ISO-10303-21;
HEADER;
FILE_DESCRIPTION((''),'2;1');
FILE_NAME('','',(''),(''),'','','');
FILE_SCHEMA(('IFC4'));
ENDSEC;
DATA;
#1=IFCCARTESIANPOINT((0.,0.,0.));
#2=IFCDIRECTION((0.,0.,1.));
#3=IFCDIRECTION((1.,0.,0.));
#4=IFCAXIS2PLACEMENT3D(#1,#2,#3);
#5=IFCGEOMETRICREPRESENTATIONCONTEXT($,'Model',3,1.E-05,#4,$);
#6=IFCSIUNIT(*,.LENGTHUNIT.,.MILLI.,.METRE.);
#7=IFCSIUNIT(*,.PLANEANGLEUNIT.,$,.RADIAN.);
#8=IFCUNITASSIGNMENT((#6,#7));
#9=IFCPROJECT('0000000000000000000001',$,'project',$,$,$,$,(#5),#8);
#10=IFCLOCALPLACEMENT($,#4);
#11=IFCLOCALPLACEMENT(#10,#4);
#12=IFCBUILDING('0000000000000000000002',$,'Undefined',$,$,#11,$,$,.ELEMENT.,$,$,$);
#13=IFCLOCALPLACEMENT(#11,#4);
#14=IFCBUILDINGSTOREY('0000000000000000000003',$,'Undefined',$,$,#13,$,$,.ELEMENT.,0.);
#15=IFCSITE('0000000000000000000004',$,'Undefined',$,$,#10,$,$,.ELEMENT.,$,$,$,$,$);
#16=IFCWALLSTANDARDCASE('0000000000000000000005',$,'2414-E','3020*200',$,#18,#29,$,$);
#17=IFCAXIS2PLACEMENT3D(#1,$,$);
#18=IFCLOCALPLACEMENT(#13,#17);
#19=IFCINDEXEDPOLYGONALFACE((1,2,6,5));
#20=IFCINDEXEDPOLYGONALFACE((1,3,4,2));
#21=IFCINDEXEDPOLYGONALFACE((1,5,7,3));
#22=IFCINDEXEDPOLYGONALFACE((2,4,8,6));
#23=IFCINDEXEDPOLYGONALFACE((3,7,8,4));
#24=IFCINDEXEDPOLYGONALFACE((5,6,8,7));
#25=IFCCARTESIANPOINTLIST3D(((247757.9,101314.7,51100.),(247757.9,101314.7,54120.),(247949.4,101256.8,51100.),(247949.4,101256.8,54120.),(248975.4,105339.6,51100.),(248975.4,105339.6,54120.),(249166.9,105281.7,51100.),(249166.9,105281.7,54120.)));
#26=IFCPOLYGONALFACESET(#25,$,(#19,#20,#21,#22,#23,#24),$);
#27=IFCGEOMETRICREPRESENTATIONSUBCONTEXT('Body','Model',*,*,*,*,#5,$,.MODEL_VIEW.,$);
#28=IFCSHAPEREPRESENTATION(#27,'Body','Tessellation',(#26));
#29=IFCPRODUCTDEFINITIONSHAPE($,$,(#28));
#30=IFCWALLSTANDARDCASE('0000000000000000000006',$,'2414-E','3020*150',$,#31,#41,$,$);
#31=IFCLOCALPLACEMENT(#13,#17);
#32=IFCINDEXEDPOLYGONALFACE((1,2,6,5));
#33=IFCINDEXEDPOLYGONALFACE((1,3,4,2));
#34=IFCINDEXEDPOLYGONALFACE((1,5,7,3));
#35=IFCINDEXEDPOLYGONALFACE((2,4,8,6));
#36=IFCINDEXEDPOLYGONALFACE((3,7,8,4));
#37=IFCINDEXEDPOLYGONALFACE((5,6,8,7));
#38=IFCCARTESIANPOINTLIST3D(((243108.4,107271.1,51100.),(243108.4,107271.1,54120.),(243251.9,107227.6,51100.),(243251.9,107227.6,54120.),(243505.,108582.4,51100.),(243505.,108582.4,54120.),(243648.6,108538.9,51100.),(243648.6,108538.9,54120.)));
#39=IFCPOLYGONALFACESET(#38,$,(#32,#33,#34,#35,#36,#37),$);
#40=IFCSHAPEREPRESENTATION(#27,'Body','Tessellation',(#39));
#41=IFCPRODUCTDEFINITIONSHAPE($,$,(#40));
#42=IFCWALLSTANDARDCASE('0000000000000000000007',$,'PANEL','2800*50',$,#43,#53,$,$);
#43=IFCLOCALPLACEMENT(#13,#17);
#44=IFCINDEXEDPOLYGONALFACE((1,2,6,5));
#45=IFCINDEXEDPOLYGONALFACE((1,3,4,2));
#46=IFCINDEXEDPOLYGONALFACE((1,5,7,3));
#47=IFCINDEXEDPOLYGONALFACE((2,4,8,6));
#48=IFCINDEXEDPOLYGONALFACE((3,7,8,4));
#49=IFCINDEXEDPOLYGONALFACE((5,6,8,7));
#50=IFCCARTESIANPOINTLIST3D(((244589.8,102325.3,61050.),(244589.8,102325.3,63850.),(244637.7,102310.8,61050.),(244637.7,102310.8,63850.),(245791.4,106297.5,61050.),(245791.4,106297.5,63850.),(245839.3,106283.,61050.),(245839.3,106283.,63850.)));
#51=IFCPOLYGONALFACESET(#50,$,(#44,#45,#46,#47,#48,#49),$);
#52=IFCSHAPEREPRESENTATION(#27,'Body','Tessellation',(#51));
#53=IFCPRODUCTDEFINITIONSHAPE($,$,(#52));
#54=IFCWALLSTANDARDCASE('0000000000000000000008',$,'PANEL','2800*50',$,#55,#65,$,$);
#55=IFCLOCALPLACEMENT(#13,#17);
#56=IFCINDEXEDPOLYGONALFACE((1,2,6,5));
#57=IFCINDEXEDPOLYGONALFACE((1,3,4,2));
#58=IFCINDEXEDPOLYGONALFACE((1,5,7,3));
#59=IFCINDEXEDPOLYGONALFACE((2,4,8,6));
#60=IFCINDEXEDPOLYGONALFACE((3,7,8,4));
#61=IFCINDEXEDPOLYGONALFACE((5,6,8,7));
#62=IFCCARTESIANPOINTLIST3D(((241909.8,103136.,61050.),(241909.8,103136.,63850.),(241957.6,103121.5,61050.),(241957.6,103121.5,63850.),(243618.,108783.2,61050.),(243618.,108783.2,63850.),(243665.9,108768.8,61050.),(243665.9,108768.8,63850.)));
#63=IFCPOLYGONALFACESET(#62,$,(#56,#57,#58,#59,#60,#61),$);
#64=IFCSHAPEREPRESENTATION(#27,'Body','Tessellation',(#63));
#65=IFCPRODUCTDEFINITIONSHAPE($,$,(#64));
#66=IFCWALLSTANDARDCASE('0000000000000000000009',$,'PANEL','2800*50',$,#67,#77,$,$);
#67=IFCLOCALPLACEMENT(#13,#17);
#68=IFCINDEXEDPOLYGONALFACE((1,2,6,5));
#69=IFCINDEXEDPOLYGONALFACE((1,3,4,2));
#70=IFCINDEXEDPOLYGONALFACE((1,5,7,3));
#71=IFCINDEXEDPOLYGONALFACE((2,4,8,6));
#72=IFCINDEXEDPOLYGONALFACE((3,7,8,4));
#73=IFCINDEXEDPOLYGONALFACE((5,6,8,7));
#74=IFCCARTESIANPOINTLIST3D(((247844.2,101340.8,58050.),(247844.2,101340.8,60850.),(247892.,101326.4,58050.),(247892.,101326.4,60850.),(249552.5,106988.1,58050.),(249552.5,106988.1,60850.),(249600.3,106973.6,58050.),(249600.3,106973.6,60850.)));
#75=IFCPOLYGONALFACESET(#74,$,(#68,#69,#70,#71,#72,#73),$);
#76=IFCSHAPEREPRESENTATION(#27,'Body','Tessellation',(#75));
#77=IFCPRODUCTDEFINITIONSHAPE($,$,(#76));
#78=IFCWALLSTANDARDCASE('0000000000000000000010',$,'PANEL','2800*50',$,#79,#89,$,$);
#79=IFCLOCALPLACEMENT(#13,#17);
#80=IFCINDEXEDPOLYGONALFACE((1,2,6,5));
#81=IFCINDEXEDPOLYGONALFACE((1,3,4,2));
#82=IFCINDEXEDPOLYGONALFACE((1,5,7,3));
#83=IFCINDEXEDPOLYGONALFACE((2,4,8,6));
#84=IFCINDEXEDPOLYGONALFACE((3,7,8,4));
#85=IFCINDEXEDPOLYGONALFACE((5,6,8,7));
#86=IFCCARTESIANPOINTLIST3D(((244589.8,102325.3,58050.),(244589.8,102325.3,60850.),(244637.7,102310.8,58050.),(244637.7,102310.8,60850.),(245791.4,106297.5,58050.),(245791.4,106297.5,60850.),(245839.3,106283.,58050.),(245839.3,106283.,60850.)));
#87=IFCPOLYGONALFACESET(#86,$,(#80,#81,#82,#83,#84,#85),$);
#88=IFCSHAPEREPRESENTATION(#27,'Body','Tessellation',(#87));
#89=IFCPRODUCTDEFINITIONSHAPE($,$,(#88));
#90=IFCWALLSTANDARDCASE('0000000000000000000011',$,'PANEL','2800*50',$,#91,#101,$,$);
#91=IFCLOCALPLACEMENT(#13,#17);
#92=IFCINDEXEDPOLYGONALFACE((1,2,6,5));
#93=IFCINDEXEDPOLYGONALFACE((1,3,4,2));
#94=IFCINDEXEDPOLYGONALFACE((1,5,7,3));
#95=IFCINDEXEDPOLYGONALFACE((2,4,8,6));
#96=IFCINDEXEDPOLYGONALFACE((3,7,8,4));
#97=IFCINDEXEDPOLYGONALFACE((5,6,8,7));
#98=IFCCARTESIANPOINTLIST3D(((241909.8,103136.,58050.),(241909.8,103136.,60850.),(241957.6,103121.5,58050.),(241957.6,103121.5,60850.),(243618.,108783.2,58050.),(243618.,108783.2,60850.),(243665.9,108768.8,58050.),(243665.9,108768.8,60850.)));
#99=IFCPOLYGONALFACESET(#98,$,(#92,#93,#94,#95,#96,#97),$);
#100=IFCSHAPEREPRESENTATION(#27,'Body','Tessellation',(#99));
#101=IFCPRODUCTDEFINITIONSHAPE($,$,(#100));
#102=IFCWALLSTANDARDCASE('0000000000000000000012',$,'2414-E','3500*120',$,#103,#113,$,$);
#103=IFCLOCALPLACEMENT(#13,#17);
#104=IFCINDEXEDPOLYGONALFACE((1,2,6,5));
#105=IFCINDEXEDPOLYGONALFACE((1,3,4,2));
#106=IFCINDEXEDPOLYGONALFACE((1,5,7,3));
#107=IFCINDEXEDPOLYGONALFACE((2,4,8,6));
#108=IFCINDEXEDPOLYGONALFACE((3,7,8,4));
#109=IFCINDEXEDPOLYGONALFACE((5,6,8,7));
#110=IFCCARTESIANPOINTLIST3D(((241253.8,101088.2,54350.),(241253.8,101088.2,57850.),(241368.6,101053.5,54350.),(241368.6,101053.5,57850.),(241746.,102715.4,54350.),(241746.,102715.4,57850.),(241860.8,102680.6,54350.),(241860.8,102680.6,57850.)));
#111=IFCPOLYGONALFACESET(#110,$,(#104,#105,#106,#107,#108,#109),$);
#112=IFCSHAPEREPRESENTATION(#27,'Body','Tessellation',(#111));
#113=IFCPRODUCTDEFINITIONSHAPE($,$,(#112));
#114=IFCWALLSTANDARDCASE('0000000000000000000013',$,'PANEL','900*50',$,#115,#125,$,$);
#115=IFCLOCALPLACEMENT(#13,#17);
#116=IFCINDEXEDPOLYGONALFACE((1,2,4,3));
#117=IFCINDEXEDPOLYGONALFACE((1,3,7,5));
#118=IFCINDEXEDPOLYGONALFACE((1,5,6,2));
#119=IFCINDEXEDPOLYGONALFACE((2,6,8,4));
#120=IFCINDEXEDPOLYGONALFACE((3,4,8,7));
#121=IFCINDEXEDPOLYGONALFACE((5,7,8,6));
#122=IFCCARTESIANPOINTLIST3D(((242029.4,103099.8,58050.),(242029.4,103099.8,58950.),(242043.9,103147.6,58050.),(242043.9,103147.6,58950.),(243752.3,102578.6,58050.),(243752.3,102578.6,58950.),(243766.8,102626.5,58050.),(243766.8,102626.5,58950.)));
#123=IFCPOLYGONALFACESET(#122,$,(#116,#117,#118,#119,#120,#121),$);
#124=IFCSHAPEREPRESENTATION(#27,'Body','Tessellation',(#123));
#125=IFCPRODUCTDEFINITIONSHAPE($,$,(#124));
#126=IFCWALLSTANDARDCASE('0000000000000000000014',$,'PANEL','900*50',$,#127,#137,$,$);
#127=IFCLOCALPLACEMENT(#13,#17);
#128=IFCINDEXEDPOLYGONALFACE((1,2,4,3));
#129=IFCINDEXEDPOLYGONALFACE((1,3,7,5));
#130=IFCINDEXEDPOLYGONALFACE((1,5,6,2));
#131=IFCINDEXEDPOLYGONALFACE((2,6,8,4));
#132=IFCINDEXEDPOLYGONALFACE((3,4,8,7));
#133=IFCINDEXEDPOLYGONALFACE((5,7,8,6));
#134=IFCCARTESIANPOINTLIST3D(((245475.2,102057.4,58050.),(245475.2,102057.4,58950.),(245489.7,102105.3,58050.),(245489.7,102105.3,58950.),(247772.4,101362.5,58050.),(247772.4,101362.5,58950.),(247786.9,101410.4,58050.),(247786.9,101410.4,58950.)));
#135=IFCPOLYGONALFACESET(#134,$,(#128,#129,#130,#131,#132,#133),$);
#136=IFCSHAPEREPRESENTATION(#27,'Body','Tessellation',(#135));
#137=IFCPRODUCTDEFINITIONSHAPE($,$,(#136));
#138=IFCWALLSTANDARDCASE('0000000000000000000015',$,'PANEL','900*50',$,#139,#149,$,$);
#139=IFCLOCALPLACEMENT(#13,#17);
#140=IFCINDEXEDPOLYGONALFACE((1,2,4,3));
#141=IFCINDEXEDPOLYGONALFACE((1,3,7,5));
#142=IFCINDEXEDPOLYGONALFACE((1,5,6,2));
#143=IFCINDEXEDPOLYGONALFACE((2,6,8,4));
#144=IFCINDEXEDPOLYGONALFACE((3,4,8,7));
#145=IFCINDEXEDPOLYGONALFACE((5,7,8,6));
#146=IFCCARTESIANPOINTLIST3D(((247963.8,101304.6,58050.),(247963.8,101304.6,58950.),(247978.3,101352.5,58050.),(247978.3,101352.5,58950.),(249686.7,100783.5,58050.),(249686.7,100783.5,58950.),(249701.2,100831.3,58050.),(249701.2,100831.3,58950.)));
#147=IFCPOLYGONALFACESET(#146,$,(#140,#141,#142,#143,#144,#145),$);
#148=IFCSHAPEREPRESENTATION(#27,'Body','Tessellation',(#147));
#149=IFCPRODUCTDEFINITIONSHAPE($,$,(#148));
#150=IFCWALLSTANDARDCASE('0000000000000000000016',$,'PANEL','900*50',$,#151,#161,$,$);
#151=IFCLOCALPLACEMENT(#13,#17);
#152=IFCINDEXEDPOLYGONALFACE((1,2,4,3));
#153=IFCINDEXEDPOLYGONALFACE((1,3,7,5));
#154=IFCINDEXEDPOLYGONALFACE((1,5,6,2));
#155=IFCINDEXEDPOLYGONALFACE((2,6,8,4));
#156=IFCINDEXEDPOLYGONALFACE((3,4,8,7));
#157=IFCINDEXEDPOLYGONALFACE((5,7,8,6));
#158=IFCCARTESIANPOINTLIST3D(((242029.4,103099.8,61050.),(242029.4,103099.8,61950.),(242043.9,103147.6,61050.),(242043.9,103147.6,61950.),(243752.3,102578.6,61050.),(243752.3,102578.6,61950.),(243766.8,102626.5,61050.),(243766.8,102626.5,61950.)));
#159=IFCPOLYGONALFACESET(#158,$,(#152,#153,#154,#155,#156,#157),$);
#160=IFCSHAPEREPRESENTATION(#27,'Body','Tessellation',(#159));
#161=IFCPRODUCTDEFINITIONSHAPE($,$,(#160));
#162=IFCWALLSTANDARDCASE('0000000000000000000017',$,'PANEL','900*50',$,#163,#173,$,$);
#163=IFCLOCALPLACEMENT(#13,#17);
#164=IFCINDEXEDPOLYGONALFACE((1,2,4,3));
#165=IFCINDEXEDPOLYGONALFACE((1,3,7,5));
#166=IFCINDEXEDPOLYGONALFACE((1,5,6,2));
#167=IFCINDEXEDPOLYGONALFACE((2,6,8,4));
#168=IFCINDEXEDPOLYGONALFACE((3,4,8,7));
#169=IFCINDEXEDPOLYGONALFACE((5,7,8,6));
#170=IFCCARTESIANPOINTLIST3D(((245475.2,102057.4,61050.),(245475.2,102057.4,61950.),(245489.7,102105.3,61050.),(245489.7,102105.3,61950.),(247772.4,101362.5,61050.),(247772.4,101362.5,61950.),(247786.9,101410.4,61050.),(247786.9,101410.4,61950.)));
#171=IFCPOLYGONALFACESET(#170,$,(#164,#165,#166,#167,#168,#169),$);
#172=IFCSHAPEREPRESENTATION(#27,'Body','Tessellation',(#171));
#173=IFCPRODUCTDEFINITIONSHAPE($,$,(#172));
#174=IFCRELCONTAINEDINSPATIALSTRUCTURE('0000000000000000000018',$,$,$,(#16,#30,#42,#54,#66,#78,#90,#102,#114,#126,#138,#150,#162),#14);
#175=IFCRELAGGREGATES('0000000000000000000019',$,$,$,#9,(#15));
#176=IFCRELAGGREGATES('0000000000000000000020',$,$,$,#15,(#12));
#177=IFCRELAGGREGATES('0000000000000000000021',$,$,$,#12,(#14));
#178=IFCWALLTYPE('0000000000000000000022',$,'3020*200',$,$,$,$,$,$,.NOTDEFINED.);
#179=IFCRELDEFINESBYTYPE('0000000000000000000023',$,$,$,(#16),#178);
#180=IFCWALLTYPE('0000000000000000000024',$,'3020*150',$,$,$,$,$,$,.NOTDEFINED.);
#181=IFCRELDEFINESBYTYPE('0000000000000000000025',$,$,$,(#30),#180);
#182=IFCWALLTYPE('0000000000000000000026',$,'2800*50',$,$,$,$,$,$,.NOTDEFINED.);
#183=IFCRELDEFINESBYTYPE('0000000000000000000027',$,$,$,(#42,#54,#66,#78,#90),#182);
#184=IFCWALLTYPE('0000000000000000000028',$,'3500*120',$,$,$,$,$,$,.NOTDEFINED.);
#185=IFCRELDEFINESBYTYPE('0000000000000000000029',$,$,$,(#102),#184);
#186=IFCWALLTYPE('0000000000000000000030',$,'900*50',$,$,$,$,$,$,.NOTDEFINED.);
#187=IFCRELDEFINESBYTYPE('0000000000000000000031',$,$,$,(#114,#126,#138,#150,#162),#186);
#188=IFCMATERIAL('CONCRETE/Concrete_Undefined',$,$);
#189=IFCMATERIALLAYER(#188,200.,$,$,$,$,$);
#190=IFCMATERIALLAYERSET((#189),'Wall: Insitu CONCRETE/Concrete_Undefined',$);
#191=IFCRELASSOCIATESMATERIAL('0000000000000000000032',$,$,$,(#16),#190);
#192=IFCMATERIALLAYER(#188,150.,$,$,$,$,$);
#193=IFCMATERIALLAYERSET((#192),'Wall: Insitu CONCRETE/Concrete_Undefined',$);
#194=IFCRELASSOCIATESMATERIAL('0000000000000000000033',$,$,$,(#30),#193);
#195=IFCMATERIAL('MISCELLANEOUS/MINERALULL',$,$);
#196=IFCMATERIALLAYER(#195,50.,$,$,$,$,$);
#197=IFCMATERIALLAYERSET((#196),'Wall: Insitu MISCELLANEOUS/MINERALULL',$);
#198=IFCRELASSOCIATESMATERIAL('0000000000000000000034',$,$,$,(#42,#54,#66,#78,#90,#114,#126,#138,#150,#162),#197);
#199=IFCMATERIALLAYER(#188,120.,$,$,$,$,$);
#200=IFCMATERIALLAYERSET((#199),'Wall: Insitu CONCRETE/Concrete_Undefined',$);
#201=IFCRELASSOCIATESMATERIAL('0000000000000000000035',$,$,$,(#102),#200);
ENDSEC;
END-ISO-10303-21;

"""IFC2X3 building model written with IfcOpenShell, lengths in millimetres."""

from ifc_helpers import new_model, si_unit, frame, frame_2d, origin_with_axes, place, context, subcontext, project, spatial, rectangle, extrude, material, layer, layer_set, layer_usage, type_object, element, save


model = new_model("IFC2X3")

# Units and contexts
model_context = context("Model", 3, precision=1e-05, world=origin_with_axes())
body_context = subcontext(model_context, "Body", "Model", "MODEL_VIEW")
ifc_project = project(units=[si_unit("LENGTHUNIT", "METRE", prefix="MILLI"), si_unit("PLANEANGLEUNIT", "RADIAN")], contexts=[model_context])

# Site, building, storey
site_placement = place(None, origin_with_axes())
site = spatial("IfcSite", under=ifc_project, at=site_placement, Name="Undefined", CompositionType="ELEMENT")
building_placement = place(site_placement, origin_with_axes())
building = spatial("IfcBuilding", under=site, at=building_placement, Name="Undefined", CompositionType="ELEMENT")
storey_placement = place(building_placement, origin_with_axes())
storey = spatial("IfcBuildingStorey", under=building, at=storey_placement, Name="Undefined", CompositionType="ELEMENT", Elevation=0.0)

# Shared definitions
ifc_material_1 = material(Name="CONCRETE/Concrete_Undefined")

# Walls
ifc_layer_1 = layer(ifc_material_1, 200.0)
ifc_layer_set_1 = layer_set([ifc_layer_1], Name="Wall: Insitu CONCRETE/Concrete_Undefined")
ifc_layer_usage_1 = layer_usage(ifc_layer_set_1, "AXIS2", "POSITIVE", -100.0)
wall_type_1 = type_object("IfcWallType", Name="3020*200", PredefinedType="NOTDEFINED")
wall_1_placement = place(storey_placement, frame((247853.6, 101285.7, 51100.0), z_axis=(0.0, 0.0, 1.0), x_axis=(0.289539, 0.957166, 0.0)))
element("IfcWallStandardCase", 1, at=wall_1_placement, inside=storey, type_object=wall_type_1, material=ifc_layer_usage_1, Name="2414-E", Description="3020*200", context=body_context, shape_type="SweptSolid", body=[
    extrude(rectangle(XDim=4205.0, YDim=200.0, at=frame_2d((0.0, 2102.5), x_axis=(0.0, -1.0))), frame((0.0, 0.0, 0.0), z_axis=(0.0, 0.0, 1.0), x_axis=(0.0, -1.0, 0.0)), (0.0, 0.0, 1.0), 3020.0),
])
ifc_layer_2 = layer(ifc_material_1, 150.0)
ifc_layer_set_2 = layer_set([ifc_layer_2], Name="Wall: Insitu CONCRETE/Concrete_Undefined")
ifc_layer_usage_2 = layer_usage(ifc_layer_set_2, "AXIS2", "POSITIVE", -75.0)
wall_type_2 = type_object("IfcWallType", Name="3020*150", PredefinedType="NOTDEFINED")
wall_2_placement = place(storey_placement, frame((243180.1, 107249.3, 51100.0), z_axis=(0.0, 0.0, 1.0), x_axis=(0.289542, 0.957165, 0.0)))
element("IfcWallStandardCase", 2, at=wall_2_placement, inside=storey, type_object=wall_type_2, material=ifc_layer_usage_2, Name="2414-E", Description="3020*150", context=body_context, shape_type="SweptSolid", body=[
    extrude(rectangle(XDim=1370.0, YDim=150.0, at=frame_2d((0.0, 685.0), x_axis=(0.0, -1.0))), frame((0.0, 0.0, 0.0), z_axis=(0.0, 0.0, 1.0), x_axis=(0.0, -1.0, 0.0)), (0.0, 0.0, 1.0), 3020.0),
])
ifc_material_2 = material(Name="MISCELLANEOUS/MINERALULL")
ifc_layer_3 = layer(ifc_material_2, 50.0)
ifc_layer_set_3 = layer_set([ifc_layer_3], Name="Wall: Insitu MISCELLANEOUS/MINERALULL")
ifc_layer_usage_3 = layer_usage(ifc_layer_set_3, "AXIS2", "POSITIVE", -25.0)
wall_type_3 = type_object("IfcWallType", Name="2800*50", PredefinedType="NOTDEFINED")
wall_3_placement = place(storey_placement, frame((244613.8, 102318.0, 61050.0), z_axis=(0.0, 0.0, 1.0), x_axis=(0.289539, 0.957166, 0.0)))
element("IfcWallStandardCase", 3, at=wall_3_placement, inside=storey, type_object=wall_type_3, material=ifc_layer_usage_3, Name="PANEL", Description="2800*50", context=body_context, shape_type="SweptSolid", body=[
    extrude(rectangle(XDim=4150.0, YDim=50.0, at=frame_2d((0.0, 2075.0), x_axis=(0.0, -1.0))), frame((0.0, 0.0, 0.0), z_axis=(0.0, 0.0, 1.0), x_axis=(0.0, -1.0, 0.0)), (0.0, 0.0, 1.0), 2800.0),
])
ifc_layer_usage_4 = layer_usage(ifc_layer_set_3, "AXIS2", "POSITIVE", -25.0)
wall_4_placement = place(storey_placement, frame((241933.7, 103128.7, 61050.0), z_axis=(0.0, 0.0, 1.0), x_axis=(0.289538, 0.957166, 0.0)))
element("IfcWallStandardCase", 4, at=wall_4_placement, inside=storey, type_object=wall_type_3, material=ifc_layer_usage_4, Name="PANEL", Description="2800*50", context=body_context, shape_type="SweptSolid", body=[
    extrude(rectangle(XDim=5900.0, YDim=50.0, at=frame_2d((0.0, 2950.0), x_axis=(0.0, -1.0))), frame((0.0, 0.0, 0.0), z_axis=(0.0, 0.0, 1.0), x_axis=(0.0, -1.0, 0.0)), (0.0, 0.0, 1.0), 2800.0),
])
ifc_layer_usage_5 = layer_usage(ifc_layer_set_3, "AXIS2", "POSITIVE", -25.0)
wall_5_placement = place(storey_placement, frame((247868.1, 101333.6, 58050.0), z_axis=(0.0, 0.0, 1.0), x_axis=(0.289538, 0.957166, 0.0)))
element("IfcWallStandardCase", 5, at=wall_5_placement, inside=storey, type_object=wall_type_3, material=ifc_layer_usage_5, Name="PANEL", Description="2800*50", context=body_context, shape_type="SweptSolid", body=[
    extrude(rectangle(XDim=5900.0, YDim=50.0, at=frame_2d((0.0, 2950.0), x_axis=(0.0, -1.0))), frame((0.0, 0.0, 0.0), z_axis=(0.0, 0.0, 1.0), x_axis=(0.0, -1.0, 0.0)), (0.0, 0.0, 1.0), 2800.0),
])
ifc_layer_usage_6 = layer_usage(ifc_layer_set_3, "AXIS2", "POSITIVE", -25.0)
wall_6_placement = place(storey_placement, frame((244613.8, 102318.0, 58050.0), z_axis=(0.0, 0.0, 1.0), x_axis=(0.289539, 0.957166, 0.0)))
element("IfcWallStandardCase", 6, at=wall_6_placement, inside=storey, type_object=wall_type_3, material=ifc_layer_usage_6, Name="PANEL", Description="2800*50", context=body_context, shape_type="SweptSolid", body=[
    extrude(rectangle(XDim=4150.0, YDim=50.0, at=frame_2d((0.0, 2075.0), x_axis=(0.0, -1.0))), frame((0.0, 0.0, 0.0), z_axis=(0.0, 0.0, 1.0), x_axis=(0.0, -1.0, 0.0)), (0.0, 0.0, 1.0), 2800.0),
])
ifc_layer_usage_7 = layer_usage(ifc_layer_set_3, "AXIS2", "POSITIVE", -25.0)
wall_7_placement = place(storey_placement, frame((241933.7, 103128.7, 58050.0), z_axis=(0.0, 0.0, 1.0), x_axis=(0.289538, 0.957166, 0.0)))
element("IfcWallStandardCase", 7, at=wall_7_placement, inside=storey, type_object=wall_type_3, material=ifc_layer_usage_7, Name="PANEL", Description="2800*50", context=body_context, shape_type="SweptSolid", body=[
    extrude(rectangle(XDim=5900.0, YDim=50.0, at=frame_2d((0.0, 2950.0), x_axis=(0.0, -1.0))), frame((0.0, 0.0, 0.0), z_axis=(0.0, 0.0, 1.0), x_axis=(0.0, -1.0, 0.0)), (0.0, 0.0, 1.0), 2800.0),
])
ifc_layer_4 = layer(ifc_material_1, 120.0)
ifc_layer_set_4 = layer_set([ifc_layer_4], Name="Wall: Insitu CONCRETE/Concrete_Undefined")
ifc_layer_usage_8 = layer_usage(ifc_layer_set_4, "AXIS2", "POSITIVE", -60.0)
wall_type_4 = type_object("IfcWallType", Name="3500*120", PredefinedType="NOTDEFINED")
wall_8_placement = place(storey_placement, frame((241803.4, 102698.0, 54350.0), z_axis=(0.0, 0.0, 1.0), x_axis=(-0.289543, -0.957165, 0.0)))
element("IfcWallStandardCase", 8, at=wall_8_placement, inside=storey, type_object=wall_type_4, material=ifc_layer_usage_8, Name="2414-E", Description="3500*120", context=body_context, shape_type="SweptSolid", body=[
    extrude(rectangle(XDim=1700.0, YDim=120.0, at=frame_2d((0.0, 850.0), x_axis=(0.0, -1.0))), frame((0.0, 0.0, 0.0), z_axis=(0.0, 0.0, 1.0), x_axis=(0.0, -1.0, 0.0)), (0.0, 0.0, 1.0), 3500.0),
])
ifc_layer_usage_9 = layer_usage(ifc_layer_set_3, "AXIS2", "POSITIVE", -25.0)
wall_type_5 = type_object("IfcWallType", Name="900*50", PredefinedType="NOTDEFINED")
wall_9_placement = place(storey_placement, frame((242036.6, 103123.7, 58050.0), z_axis=(0.0, 0.0, 1.0), x_axis=(0.957166, -0.289541, 0.0)))
element("IfcWallStandardCase", 9, at=wall_9_placement, inside=storey, type_object=wall_type_5, material=ifc_layer_usage_9, Name="PANEL", Description="900*50", context=body_context, shape_type="SweptSolid", body=[
    extrude(rectangle(XDim=1800.0, YDim=50.0, at=frame_2d((0.0, 900.0), x_axis=(0.0, -1.0))), frame((0.0, 0.0, 0.0), z_axis=(0.0, 0.0, 1.0), x_axis=(0.0, -1.0, 0.0)), (0.0, 0.0, 1.0), 900.0),
])
ifc_layer_usage_10 = layer_usage(ifc_layer_set_3, "AXIS2", "POSITIVE", -25.0)
wall_10_placement = place(storey_placement, frame((245482.4, 102081.4, 58050.0), z_axis=(0.0, 0.0, 1.0), x_axis=(0.957166, -0.289539, 0.0)))
element("IfcWallStandardCase", 10, at=wall_10_placement, inside=storey, type_object=wall_type_5, material=ifc_layer_usage_10, Name="PANEL", Description="900*50", context=body_context, shape_type="SweptSolid", body=[
    extrude(rectangle(XDim=2400.0, YDim=50.0, at=frame_2d((0.0, 1200.0), x_axis=(0.0, -1.0))), frame((0.0, 0.0, 0.0), z_axis=(0.0, 0.0, 1.0), x_axis=(0.0, -1.0, 0.0)), (0.0, 0.0, 1.0), 900.0),
])
ifc_layer_usage_11 = layer_usage(ifc_layer_set_3, "AXIS2", "POSITIVE", -25.0)
wall_11_placement = place(storey_placement, frame((247971.1, 101328.6, 58050.0), z_axis=(0.0, 0.0, 1.0), x_axis=(0.957166, -0.289541, 0.0)))
element("IfcWallStandardCase", 11, at=wall_11_placement, inside=storey, type_object=wall_type_5, material=ifc_layer_usage_11, Name="PANEL", Description="900*50", context=body_context, shape_type="SweptSolid", body=[
    extrude(rectangle(XDim=1800.0, YDim=50.0, at=frame_2d((0.0, 900.0), x_axis=(0.0, -1.0))), frame((0.0, 0.0, 0.0), z_axis=(0.0, 0.0, 1.0), x_axis=(0.0, -1.0, 0.0)), (0.0, 0.0, 1.0), 900.0),
])
ifc_layer_usage_12 = layer_usage(ifc_layer_set_3, "AXIS2", "POSITIVE", -25.0)
wall_12_placement = place(storey_placement, frame((242036.6, 103123.7, 61050.0), z_axis=(0.0, 0.0, 1.0), x_axis=(0.957166, -0.289541, 0.0)))
element("IfcWallStandardCase", 12, at=wall_12_placement, inside=storey, type_object=wall_type_5, material=ifc_layer_usage_12, Name="PANEL", Description="900*50", context=body_context, shape_type="SweptSolid", body=[
    extrude(rectangle(XDim=1800.0, YDim=50.0, at=frame_2d((0.0, 900.0), x_axis=(0.0, -1.0))), frame((0.0, 0.0, 0.0), z_axis=(0.0, 0.0, 1.0), x_axis=(0.0, -1.0, 0.0)), (0.0, 0.0, 1.0), 900.0),
])
ifc_layer_usage_13 = layer_usage(ifc_layer_set_3, "AXIS2", "POSITIVE", -25.0)
wall_13_placement = place(storey_placement, frame((245482.4, 102081.4, 61050.0), z_axis=(0.0, 0.0, 1.0), x_axis=(0.957166, -0.289539, 0.0)))
element("IfcWallStandardCase", 13, at=wall_13_placement, inside=storey, type_object=wall_type_5, material=ifc_layer_usage_13, Name="PANEL", Description="900*50", context=body_context, shape_type="SweptSolid", body=[
    extrude(rectangle(XDim=2400.0, YDim=50.0, at=frame_2d((0.0, 1200.0), x_axis=(0.0, -1.0))), frame((0.0, 0.0, 0.0), z_axis=(0.0, 0.0, 1.0), x_axis=(0.0, -1.0, 0.0)), (0.0, 0.0, 1.0), 900.0),
])

save(model, "model.ifc")
